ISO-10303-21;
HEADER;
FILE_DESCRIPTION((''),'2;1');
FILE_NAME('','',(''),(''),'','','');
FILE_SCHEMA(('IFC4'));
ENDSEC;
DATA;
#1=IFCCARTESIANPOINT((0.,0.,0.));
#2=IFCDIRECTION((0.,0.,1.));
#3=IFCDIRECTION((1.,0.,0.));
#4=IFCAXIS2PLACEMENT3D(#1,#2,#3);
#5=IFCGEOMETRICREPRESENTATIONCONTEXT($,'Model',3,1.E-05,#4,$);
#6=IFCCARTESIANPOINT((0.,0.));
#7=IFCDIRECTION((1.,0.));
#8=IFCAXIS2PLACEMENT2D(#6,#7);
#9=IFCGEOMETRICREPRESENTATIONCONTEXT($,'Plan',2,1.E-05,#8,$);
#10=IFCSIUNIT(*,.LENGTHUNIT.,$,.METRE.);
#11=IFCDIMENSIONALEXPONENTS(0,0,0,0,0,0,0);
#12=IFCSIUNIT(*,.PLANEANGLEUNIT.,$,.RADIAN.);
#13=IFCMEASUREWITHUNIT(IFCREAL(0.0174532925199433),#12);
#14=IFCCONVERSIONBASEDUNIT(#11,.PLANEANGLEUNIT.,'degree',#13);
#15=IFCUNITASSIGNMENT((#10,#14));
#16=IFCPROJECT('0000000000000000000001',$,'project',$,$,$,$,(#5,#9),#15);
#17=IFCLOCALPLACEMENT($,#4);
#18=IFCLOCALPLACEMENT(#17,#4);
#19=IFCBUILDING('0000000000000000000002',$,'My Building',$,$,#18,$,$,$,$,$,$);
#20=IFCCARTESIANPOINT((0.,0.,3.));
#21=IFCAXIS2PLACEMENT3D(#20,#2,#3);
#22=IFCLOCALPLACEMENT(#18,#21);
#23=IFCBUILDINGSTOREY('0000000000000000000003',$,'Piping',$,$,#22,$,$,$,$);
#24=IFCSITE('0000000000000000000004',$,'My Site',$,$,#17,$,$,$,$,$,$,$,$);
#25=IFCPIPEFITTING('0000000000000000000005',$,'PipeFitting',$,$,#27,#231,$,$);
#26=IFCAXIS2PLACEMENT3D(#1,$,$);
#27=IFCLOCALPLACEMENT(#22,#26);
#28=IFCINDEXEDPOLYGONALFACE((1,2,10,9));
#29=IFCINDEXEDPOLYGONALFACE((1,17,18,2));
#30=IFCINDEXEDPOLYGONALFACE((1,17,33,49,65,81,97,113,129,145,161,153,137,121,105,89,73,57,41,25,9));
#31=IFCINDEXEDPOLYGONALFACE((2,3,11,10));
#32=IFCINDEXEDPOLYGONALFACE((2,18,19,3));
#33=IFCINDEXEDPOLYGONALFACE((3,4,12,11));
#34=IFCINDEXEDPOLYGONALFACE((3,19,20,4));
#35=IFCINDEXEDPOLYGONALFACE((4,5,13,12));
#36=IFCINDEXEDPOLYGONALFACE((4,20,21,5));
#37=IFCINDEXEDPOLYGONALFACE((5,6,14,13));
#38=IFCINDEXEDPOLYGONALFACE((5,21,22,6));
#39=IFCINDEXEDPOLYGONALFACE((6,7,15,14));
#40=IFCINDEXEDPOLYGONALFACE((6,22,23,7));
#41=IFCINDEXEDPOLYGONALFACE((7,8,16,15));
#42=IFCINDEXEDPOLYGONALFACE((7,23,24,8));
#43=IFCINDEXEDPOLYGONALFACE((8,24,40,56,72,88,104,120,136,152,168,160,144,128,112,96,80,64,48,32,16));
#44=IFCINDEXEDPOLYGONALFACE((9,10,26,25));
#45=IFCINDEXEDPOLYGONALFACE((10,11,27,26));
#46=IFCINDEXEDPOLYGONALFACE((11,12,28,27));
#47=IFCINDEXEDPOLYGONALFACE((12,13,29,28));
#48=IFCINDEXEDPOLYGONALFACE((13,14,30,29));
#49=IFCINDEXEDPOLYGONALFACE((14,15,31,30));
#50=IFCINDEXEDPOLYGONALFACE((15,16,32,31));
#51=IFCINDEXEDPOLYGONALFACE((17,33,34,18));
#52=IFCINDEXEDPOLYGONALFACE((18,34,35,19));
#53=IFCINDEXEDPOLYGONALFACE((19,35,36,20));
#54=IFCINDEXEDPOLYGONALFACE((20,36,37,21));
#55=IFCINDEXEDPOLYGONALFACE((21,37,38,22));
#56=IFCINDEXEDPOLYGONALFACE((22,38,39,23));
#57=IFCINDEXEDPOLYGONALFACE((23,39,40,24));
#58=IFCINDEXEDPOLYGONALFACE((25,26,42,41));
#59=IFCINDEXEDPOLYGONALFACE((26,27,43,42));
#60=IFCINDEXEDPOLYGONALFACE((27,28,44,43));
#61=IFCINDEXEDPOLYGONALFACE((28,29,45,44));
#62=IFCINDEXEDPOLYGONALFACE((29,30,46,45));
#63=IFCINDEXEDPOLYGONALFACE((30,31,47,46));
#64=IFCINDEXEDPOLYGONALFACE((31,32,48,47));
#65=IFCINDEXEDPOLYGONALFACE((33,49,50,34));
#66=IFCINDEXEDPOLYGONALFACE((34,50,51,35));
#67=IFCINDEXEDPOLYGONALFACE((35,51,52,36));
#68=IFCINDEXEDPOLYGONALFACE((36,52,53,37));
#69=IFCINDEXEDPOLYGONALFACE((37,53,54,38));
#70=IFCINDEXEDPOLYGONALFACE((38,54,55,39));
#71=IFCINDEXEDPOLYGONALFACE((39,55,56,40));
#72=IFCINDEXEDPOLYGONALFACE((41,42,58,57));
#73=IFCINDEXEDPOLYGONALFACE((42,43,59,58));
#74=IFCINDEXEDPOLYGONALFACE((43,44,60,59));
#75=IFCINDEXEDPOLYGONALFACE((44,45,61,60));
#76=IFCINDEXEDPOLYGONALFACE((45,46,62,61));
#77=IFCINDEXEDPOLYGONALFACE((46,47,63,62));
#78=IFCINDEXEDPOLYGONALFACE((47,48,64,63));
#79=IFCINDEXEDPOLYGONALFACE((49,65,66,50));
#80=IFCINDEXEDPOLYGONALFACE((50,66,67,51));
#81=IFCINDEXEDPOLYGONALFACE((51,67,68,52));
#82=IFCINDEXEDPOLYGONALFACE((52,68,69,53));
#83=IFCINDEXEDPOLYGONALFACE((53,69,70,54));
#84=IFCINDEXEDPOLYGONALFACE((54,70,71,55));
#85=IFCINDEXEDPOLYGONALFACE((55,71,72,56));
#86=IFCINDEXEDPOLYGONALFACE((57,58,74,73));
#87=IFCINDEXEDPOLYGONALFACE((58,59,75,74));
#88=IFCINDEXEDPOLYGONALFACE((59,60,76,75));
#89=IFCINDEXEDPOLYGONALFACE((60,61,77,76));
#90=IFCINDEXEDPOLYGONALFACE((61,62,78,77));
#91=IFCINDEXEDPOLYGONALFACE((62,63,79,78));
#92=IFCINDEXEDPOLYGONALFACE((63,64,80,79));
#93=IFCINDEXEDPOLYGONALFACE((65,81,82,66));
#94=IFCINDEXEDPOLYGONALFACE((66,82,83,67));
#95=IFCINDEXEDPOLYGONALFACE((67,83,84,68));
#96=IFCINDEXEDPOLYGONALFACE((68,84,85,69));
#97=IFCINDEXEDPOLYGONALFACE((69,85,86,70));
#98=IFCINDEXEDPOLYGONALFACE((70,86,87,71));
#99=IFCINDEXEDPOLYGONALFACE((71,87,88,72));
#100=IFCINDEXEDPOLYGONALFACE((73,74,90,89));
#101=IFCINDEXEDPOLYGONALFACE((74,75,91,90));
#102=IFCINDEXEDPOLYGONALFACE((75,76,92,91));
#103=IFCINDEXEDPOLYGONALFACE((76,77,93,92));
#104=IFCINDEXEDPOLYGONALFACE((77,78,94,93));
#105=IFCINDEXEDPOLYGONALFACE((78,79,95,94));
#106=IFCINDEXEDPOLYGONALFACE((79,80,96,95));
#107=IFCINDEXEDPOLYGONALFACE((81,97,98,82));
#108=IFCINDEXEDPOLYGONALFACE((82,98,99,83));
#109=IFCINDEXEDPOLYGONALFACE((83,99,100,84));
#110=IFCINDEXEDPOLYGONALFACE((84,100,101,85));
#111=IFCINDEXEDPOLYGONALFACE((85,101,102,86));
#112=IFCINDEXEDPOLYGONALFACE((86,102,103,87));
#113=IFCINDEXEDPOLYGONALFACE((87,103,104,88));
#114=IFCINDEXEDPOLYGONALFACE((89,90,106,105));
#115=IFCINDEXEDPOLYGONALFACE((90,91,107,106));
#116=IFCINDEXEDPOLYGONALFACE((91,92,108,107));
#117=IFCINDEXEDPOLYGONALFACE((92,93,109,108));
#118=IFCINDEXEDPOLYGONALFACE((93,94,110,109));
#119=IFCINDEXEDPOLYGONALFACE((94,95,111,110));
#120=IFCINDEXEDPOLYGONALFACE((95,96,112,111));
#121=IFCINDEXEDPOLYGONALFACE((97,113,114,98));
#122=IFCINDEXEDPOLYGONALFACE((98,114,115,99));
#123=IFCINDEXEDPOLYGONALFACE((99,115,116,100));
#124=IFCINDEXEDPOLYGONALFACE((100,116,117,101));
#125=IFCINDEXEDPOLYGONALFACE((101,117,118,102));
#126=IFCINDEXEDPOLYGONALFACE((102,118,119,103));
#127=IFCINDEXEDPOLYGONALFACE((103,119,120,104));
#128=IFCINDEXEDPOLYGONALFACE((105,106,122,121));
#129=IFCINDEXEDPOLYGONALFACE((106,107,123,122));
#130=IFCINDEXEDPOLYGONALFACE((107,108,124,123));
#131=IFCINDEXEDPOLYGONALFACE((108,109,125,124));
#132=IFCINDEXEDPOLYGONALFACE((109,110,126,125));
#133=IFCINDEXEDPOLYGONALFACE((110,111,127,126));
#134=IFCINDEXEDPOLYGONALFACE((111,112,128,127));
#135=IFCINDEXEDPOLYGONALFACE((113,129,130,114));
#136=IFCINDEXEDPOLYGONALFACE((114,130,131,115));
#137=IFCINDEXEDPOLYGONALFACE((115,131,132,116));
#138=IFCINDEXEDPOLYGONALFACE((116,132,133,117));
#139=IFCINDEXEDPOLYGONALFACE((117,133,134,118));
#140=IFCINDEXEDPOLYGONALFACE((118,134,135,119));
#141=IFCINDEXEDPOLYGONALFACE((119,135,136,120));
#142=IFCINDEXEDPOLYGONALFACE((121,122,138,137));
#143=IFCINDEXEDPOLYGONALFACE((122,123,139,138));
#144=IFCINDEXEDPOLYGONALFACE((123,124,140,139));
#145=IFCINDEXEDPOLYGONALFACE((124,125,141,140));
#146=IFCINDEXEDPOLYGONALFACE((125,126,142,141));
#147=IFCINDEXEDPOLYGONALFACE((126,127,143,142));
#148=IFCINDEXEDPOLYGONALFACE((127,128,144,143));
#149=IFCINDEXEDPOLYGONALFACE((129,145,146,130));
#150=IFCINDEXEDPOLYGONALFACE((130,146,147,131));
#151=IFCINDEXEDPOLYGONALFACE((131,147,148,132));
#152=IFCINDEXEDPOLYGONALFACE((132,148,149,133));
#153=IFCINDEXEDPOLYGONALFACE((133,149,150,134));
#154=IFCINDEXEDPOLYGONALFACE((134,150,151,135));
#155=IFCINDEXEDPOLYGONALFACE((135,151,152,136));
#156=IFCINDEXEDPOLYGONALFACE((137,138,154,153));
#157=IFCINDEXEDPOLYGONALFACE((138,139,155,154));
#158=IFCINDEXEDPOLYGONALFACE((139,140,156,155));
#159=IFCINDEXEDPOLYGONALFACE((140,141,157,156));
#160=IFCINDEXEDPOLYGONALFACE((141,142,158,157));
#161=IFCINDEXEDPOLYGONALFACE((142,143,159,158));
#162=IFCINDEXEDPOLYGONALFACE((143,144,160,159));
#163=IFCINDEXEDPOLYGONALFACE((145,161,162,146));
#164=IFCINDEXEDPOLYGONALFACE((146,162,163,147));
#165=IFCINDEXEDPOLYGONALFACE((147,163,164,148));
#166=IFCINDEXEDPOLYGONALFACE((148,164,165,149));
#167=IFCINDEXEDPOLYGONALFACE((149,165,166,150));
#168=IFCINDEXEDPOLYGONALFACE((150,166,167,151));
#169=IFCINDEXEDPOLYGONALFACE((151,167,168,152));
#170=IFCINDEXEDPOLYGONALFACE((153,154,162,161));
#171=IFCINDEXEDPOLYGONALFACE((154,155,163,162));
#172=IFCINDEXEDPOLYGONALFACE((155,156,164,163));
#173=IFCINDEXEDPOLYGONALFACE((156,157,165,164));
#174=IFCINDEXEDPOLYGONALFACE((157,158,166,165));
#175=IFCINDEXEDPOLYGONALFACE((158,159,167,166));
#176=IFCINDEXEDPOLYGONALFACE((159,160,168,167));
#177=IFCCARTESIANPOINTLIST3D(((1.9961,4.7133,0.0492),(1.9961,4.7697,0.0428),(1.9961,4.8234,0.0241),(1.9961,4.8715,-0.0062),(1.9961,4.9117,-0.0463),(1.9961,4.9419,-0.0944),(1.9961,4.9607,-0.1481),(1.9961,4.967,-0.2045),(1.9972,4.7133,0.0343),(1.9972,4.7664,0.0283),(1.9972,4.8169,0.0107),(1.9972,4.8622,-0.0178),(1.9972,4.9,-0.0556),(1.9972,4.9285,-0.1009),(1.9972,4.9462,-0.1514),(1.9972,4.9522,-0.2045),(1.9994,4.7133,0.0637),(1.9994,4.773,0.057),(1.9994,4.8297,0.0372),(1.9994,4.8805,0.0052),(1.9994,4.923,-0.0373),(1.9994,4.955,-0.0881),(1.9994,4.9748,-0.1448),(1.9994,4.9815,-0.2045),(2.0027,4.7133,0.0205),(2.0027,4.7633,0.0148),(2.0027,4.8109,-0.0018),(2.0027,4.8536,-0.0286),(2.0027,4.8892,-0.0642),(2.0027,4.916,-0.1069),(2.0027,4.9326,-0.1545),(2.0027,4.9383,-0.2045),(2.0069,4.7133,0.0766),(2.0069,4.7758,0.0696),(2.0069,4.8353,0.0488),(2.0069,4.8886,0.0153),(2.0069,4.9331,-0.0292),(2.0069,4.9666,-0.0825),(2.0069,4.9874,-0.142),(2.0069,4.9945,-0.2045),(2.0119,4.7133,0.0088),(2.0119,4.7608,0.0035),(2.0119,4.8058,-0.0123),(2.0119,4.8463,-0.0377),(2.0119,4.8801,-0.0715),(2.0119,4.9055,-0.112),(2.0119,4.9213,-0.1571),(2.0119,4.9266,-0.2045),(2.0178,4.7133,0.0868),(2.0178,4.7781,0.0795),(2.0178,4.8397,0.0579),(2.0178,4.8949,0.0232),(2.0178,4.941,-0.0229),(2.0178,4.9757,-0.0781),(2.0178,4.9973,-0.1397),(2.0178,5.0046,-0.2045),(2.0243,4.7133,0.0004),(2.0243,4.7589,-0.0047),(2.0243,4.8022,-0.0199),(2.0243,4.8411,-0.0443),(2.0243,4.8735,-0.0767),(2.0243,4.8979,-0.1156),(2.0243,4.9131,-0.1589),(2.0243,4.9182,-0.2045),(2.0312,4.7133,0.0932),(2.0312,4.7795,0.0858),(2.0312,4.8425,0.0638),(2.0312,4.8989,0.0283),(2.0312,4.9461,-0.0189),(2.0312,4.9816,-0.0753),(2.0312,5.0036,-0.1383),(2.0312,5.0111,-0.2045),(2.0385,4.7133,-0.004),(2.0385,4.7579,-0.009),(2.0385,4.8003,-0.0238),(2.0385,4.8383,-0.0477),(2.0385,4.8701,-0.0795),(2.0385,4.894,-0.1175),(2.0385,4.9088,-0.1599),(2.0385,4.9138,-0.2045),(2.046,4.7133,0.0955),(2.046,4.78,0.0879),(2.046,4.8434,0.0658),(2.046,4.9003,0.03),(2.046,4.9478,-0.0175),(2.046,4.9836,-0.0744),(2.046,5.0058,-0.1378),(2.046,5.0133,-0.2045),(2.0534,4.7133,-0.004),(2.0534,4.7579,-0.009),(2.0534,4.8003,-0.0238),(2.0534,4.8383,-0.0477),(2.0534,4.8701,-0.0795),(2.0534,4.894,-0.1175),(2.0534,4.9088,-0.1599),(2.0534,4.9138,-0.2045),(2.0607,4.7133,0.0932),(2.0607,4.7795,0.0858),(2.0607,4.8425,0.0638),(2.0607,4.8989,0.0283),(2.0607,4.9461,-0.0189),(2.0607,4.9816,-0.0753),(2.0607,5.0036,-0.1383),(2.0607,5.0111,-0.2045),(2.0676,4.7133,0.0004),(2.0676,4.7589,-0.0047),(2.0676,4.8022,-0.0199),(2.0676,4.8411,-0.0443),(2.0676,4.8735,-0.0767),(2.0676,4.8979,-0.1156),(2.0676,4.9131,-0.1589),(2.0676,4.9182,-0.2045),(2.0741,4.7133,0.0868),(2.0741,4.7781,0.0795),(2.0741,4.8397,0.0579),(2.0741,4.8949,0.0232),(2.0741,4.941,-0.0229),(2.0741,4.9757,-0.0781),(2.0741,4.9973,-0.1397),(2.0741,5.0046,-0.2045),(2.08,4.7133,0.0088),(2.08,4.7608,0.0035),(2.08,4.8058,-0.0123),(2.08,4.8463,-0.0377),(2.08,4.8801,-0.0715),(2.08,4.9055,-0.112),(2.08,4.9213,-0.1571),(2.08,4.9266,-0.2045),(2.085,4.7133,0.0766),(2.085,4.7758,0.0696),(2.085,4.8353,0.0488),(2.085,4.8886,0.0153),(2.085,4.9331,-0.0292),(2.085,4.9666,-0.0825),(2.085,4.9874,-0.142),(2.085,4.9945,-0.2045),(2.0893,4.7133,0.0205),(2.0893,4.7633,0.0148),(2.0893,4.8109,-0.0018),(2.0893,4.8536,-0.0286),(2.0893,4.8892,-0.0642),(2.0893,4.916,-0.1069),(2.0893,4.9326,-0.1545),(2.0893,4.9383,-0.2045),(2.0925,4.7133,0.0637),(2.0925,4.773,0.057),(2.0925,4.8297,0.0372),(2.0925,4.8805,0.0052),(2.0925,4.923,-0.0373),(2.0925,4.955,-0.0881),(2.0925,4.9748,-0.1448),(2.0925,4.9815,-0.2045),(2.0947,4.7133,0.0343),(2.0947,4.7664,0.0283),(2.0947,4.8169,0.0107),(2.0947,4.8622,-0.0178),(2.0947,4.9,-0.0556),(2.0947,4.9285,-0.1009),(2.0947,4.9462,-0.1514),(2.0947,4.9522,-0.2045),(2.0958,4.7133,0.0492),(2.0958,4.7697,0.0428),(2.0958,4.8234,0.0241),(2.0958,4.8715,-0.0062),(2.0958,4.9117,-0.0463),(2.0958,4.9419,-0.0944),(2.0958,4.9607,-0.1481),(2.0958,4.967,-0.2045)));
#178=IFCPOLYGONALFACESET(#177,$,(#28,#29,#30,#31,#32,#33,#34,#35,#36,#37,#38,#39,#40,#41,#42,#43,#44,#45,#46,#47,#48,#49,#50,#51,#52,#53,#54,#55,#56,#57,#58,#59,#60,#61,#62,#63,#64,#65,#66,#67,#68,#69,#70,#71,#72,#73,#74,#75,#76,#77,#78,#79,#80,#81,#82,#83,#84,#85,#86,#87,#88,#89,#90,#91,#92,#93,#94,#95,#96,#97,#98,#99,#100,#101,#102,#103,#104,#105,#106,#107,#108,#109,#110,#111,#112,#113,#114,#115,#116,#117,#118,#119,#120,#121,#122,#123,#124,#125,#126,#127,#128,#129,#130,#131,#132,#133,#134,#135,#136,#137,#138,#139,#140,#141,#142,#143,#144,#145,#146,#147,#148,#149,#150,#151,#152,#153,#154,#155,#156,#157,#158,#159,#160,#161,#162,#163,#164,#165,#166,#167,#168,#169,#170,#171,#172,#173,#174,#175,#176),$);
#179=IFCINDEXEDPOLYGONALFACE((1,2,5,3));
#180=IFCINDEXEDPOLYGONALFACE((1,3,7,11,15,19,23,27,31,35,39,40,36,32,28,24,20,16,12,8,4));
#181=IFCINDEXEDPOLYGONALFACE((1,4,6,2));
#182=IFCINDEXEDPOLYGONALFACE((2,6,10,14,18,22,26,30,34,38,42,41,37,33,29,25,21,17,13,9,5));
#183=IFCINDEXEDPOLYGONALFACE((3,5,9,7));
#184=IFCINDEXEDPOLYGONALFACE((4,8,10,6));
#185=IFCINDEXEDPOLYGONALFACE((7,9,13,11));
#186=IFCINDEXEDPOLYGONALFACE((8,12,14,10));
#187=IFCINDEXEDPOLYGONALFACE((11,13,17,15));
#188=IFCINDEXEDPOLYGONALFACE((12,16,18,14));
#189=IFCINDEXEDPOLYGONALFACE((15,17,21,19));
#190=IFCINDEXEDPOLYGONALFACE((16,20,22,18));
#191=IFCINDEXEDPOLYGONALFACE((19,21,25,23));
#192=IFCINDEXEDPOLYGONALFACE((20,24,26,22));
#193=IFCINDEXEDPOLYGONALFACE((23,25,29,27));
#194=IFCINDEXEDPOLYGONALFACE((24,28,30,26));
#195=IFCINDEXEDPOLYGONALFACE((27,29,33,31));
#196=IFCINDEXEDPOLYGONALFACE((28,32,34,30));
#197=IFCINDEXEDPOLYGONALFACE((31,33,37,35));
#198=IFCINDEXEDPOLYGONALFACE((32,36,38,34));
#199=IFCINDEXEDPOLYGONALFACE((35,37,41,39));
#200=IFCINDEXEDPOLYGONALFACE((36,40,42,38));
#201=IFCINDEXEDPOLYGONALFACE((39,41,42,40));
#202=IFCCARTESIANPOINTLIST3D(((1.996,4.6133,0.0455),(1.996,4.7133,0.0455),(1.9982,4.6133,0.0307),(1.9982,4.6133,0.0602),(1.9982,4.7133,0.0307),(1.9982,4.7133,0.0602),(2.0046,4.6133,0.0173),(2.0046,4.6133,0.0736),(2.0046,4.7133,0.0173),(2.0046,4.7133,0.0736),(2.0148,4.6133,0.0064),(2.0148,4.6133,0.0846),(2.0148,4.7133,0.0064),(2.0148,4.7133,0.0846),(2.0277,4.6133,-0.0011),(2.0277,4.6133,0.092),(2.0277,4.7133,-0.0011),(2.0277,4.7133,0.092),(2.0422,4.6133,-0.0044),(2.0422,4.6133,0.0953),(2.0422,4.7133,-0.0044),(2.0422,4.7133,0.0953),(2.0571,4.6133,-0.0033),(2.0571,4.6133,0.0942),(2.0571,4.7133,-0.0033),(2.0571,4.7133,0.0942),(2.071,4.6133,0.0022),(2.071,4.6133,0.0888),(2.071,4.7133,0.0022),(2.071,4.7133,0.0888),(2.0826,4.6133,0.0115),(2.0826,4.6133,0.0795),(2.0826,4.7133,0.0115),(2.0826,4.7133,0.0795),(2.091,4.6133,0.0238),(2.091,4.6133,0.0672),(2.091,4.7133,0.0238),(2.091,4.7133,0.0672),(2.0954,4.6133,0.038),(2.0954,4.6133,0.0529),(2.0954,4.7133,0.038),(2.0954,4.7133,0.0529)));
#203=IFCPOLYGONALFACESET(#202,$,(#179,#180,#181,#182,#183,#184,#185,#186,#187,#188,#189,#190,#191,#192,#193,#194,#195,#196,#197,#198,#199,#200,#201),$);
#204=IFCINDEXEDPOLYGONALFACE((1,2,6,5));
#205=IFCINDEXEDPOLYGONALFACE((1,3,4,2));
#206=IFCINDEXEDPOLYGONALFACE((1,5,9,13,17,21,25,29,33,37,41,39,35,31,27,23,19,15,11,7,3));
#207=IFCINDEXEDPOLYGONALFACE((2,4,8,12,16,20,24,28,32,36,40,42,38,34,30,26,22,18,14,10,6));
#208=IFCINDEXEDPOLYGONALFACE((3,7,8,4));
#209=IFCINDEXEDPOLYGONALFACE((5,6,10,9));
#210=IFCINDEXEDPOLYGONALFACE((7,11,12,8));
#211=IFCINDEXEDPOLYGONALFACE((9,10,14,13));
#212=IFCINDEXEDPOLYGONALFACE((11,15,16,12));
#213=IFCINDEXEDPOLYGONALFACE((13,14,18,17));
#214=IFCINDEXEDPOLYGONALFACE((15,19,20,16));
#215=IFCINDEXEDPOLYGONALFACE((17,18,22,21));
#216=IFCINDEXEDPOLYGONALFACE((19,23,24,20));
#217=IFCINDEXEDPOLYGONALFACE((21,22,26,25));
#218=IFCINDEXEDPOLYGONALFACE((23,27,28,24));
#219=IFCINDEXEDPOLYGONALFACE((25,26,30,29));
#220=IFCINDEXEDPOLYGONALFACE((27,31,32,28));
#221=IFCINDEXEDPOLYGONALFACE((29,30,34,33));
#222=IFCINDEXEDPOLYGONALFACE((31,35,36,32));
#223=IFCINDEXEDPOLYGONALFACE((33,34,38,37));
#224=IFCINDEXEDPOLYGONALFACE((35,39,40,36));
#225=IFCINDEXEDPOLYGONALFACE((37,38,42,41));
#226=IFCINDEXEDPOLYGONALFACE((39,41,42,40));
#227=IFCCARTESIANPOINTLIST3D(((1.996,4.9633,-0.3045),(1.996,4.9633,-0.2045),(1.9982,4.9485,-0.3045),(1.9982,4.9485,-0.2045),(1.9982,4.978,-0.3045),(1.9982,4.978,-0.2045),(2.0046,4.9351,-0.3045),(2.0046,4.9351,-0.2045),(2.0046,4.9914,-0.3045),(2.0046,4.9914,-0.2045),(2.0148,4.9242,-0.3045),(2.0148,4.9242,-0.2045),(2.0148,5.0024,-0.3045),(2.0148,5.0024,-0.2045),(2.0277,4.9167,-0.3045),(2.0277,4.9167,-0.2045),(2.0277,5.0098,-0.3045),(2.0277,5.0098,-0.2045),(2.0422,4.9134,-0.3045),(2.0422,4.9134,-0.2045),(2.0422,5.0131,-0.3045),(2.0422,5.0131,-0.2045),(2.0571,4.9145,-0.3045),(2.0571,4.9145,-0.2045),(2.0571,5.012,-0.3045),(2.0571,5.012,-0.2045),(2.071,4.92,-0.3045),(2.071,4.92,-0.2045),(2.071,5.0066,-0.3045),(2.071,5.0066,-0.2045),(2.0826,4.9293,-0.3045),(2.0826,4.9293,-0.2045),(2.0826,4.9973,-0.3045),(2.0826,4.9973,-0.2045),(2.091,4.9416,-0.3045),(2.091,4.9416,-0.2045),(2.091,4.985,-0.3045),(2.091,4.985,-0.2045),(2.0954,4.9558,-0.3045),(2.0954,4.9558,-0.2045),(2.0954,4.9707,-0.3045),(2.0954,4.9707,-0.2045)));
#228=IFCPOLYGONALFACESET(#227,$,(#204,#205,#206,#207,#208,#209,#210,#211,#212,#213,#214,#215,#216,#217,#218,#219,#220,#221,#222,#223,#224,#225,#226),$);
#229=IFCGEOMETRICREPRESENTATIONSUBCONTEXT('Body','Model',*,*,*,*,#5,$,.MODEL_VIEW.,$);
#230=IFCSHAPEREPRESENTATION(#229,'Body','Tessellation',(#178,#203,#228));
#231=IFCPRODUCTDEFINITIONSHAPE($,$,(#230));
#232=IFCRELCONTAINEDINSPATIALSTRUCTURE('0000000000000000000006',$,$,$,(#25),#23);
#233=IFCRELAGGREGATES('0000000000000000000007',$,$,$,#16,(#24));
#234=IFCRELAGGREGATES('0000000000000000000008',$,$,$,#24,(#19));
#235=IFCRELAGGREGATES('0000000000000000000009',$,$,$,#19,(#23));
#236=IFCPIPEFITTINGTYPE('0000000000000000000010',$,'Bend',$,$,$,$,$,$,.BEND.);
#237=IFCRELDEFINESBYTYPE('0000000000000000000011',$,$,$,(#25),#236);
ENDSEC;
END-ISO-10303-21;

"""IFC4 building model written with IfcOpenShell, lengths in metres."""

from ifc_helpers import new_model, entity, si_unit, converted_unit, frame, origin_with_axes, origin_2d_with_axis, place, context, subcontext, project, spatial, circle, extrude, source, transform, mapped, type_object, type_shapes, element, save


model = new_model("IFC4")

# Units and contexts
model_context = context("Model", 3, precision=1e-05, world=origin_with_axes())
plan_context = context("Plan", 2, precision=1e-05, world=origin_2d_with_axis())
body_context = subcontext(model_context, "Body", "Model", "MODEL_VIEW")
ifc_project = project(units=[si_unit("LENGTHUNIT", "METRE"), converted_unit("PLANEANGLEUNIT", "degree", entity("IfcReal", 0.0174532925199433), si_unit("PLANEANGLEUNIT", "RADIAN"), dimensions=[0, 0, 0, 0, 0, 0, 0])], contexts=[model_context, plan_context])

# Site, building, storey
site_placement = place(None, origin_with_axes())
site = spatial("IfcSite", under=ifc_project, at=site_placement, Name="My Site")
building_placement = place(site_placement, origin_with_axes())
building = spatial("IfcBuilding", under=site, at=building_placement, Name="My Building")
storey_placement = place(building_placement, frame((0.0, 0.0, 3.0), z_axis=(0.0, 0.0, 1.0), x_axis=(1.0, 0.0, 0.0)))
storey = spatial("IfcBuildingStorey", under=building, at=storey_placement, Name="Piping")

# Pipe fitting
pipe_fitting_type_1 = type_object("IfcPipeFittingType", Name="Bend", PredefinedType="BEND")
shared_shape_1 = source(origin_with_axes(), body_context, "Body", "SolidModel", [
    entity("IfcSweptDiskSolid", entity("IfcIndexedPolyCurve", entity("IfcCartesianPointList3D", [[0.0, 0.0, 0.1], [0.0, -0.0732, 0.2768], [0.0, -0.25, 0.35]]), [entity("IfcArcIndex", [1, 2, 3])]), 0.05),
    extrude(circle(Radius=0.05), origin_with_axes(), (0.0, 0.0, 1.0), 0.1),
    extrude(circle(Radius=0.05), frame((0.0, -0.25, 0.35), z_axis=(0.0, -1.0, 0.0), x_axis=(1.0, 0.0, 0.0)), (0.0, 0.0, 1.0), 0.1),
])
type_shapes(pipe_fitting_type_1, [shared_shape_1])
for number, where, z_axis, x_axis, name in (
    (1, (2.046, 4.6133, 0.0455), (0.0, 1.0, 0.0), (-1.0, 0.0, 0.0), "PipeFitting"),
):
    element("IfcPipeFitting", number, at=place(storey_placement, frame(where, z_axis=z_axis, x_axis=x_axis)), inside=storey, type_object=pipe_fitting_type_1, Name=name, context=body_context, shape_type="MappedRepresentation", body=[
        mapped(shared_shape_1, transform((0.0, 0.0, 0.0), x_axis=(1.0, 0.0, 0.0), y_axis=(0.0, 1.0, 0.0), z_axis=(0.0, 0.0, 1.0), scale=1.0)),
    ])

save(model, "model.ifc")
